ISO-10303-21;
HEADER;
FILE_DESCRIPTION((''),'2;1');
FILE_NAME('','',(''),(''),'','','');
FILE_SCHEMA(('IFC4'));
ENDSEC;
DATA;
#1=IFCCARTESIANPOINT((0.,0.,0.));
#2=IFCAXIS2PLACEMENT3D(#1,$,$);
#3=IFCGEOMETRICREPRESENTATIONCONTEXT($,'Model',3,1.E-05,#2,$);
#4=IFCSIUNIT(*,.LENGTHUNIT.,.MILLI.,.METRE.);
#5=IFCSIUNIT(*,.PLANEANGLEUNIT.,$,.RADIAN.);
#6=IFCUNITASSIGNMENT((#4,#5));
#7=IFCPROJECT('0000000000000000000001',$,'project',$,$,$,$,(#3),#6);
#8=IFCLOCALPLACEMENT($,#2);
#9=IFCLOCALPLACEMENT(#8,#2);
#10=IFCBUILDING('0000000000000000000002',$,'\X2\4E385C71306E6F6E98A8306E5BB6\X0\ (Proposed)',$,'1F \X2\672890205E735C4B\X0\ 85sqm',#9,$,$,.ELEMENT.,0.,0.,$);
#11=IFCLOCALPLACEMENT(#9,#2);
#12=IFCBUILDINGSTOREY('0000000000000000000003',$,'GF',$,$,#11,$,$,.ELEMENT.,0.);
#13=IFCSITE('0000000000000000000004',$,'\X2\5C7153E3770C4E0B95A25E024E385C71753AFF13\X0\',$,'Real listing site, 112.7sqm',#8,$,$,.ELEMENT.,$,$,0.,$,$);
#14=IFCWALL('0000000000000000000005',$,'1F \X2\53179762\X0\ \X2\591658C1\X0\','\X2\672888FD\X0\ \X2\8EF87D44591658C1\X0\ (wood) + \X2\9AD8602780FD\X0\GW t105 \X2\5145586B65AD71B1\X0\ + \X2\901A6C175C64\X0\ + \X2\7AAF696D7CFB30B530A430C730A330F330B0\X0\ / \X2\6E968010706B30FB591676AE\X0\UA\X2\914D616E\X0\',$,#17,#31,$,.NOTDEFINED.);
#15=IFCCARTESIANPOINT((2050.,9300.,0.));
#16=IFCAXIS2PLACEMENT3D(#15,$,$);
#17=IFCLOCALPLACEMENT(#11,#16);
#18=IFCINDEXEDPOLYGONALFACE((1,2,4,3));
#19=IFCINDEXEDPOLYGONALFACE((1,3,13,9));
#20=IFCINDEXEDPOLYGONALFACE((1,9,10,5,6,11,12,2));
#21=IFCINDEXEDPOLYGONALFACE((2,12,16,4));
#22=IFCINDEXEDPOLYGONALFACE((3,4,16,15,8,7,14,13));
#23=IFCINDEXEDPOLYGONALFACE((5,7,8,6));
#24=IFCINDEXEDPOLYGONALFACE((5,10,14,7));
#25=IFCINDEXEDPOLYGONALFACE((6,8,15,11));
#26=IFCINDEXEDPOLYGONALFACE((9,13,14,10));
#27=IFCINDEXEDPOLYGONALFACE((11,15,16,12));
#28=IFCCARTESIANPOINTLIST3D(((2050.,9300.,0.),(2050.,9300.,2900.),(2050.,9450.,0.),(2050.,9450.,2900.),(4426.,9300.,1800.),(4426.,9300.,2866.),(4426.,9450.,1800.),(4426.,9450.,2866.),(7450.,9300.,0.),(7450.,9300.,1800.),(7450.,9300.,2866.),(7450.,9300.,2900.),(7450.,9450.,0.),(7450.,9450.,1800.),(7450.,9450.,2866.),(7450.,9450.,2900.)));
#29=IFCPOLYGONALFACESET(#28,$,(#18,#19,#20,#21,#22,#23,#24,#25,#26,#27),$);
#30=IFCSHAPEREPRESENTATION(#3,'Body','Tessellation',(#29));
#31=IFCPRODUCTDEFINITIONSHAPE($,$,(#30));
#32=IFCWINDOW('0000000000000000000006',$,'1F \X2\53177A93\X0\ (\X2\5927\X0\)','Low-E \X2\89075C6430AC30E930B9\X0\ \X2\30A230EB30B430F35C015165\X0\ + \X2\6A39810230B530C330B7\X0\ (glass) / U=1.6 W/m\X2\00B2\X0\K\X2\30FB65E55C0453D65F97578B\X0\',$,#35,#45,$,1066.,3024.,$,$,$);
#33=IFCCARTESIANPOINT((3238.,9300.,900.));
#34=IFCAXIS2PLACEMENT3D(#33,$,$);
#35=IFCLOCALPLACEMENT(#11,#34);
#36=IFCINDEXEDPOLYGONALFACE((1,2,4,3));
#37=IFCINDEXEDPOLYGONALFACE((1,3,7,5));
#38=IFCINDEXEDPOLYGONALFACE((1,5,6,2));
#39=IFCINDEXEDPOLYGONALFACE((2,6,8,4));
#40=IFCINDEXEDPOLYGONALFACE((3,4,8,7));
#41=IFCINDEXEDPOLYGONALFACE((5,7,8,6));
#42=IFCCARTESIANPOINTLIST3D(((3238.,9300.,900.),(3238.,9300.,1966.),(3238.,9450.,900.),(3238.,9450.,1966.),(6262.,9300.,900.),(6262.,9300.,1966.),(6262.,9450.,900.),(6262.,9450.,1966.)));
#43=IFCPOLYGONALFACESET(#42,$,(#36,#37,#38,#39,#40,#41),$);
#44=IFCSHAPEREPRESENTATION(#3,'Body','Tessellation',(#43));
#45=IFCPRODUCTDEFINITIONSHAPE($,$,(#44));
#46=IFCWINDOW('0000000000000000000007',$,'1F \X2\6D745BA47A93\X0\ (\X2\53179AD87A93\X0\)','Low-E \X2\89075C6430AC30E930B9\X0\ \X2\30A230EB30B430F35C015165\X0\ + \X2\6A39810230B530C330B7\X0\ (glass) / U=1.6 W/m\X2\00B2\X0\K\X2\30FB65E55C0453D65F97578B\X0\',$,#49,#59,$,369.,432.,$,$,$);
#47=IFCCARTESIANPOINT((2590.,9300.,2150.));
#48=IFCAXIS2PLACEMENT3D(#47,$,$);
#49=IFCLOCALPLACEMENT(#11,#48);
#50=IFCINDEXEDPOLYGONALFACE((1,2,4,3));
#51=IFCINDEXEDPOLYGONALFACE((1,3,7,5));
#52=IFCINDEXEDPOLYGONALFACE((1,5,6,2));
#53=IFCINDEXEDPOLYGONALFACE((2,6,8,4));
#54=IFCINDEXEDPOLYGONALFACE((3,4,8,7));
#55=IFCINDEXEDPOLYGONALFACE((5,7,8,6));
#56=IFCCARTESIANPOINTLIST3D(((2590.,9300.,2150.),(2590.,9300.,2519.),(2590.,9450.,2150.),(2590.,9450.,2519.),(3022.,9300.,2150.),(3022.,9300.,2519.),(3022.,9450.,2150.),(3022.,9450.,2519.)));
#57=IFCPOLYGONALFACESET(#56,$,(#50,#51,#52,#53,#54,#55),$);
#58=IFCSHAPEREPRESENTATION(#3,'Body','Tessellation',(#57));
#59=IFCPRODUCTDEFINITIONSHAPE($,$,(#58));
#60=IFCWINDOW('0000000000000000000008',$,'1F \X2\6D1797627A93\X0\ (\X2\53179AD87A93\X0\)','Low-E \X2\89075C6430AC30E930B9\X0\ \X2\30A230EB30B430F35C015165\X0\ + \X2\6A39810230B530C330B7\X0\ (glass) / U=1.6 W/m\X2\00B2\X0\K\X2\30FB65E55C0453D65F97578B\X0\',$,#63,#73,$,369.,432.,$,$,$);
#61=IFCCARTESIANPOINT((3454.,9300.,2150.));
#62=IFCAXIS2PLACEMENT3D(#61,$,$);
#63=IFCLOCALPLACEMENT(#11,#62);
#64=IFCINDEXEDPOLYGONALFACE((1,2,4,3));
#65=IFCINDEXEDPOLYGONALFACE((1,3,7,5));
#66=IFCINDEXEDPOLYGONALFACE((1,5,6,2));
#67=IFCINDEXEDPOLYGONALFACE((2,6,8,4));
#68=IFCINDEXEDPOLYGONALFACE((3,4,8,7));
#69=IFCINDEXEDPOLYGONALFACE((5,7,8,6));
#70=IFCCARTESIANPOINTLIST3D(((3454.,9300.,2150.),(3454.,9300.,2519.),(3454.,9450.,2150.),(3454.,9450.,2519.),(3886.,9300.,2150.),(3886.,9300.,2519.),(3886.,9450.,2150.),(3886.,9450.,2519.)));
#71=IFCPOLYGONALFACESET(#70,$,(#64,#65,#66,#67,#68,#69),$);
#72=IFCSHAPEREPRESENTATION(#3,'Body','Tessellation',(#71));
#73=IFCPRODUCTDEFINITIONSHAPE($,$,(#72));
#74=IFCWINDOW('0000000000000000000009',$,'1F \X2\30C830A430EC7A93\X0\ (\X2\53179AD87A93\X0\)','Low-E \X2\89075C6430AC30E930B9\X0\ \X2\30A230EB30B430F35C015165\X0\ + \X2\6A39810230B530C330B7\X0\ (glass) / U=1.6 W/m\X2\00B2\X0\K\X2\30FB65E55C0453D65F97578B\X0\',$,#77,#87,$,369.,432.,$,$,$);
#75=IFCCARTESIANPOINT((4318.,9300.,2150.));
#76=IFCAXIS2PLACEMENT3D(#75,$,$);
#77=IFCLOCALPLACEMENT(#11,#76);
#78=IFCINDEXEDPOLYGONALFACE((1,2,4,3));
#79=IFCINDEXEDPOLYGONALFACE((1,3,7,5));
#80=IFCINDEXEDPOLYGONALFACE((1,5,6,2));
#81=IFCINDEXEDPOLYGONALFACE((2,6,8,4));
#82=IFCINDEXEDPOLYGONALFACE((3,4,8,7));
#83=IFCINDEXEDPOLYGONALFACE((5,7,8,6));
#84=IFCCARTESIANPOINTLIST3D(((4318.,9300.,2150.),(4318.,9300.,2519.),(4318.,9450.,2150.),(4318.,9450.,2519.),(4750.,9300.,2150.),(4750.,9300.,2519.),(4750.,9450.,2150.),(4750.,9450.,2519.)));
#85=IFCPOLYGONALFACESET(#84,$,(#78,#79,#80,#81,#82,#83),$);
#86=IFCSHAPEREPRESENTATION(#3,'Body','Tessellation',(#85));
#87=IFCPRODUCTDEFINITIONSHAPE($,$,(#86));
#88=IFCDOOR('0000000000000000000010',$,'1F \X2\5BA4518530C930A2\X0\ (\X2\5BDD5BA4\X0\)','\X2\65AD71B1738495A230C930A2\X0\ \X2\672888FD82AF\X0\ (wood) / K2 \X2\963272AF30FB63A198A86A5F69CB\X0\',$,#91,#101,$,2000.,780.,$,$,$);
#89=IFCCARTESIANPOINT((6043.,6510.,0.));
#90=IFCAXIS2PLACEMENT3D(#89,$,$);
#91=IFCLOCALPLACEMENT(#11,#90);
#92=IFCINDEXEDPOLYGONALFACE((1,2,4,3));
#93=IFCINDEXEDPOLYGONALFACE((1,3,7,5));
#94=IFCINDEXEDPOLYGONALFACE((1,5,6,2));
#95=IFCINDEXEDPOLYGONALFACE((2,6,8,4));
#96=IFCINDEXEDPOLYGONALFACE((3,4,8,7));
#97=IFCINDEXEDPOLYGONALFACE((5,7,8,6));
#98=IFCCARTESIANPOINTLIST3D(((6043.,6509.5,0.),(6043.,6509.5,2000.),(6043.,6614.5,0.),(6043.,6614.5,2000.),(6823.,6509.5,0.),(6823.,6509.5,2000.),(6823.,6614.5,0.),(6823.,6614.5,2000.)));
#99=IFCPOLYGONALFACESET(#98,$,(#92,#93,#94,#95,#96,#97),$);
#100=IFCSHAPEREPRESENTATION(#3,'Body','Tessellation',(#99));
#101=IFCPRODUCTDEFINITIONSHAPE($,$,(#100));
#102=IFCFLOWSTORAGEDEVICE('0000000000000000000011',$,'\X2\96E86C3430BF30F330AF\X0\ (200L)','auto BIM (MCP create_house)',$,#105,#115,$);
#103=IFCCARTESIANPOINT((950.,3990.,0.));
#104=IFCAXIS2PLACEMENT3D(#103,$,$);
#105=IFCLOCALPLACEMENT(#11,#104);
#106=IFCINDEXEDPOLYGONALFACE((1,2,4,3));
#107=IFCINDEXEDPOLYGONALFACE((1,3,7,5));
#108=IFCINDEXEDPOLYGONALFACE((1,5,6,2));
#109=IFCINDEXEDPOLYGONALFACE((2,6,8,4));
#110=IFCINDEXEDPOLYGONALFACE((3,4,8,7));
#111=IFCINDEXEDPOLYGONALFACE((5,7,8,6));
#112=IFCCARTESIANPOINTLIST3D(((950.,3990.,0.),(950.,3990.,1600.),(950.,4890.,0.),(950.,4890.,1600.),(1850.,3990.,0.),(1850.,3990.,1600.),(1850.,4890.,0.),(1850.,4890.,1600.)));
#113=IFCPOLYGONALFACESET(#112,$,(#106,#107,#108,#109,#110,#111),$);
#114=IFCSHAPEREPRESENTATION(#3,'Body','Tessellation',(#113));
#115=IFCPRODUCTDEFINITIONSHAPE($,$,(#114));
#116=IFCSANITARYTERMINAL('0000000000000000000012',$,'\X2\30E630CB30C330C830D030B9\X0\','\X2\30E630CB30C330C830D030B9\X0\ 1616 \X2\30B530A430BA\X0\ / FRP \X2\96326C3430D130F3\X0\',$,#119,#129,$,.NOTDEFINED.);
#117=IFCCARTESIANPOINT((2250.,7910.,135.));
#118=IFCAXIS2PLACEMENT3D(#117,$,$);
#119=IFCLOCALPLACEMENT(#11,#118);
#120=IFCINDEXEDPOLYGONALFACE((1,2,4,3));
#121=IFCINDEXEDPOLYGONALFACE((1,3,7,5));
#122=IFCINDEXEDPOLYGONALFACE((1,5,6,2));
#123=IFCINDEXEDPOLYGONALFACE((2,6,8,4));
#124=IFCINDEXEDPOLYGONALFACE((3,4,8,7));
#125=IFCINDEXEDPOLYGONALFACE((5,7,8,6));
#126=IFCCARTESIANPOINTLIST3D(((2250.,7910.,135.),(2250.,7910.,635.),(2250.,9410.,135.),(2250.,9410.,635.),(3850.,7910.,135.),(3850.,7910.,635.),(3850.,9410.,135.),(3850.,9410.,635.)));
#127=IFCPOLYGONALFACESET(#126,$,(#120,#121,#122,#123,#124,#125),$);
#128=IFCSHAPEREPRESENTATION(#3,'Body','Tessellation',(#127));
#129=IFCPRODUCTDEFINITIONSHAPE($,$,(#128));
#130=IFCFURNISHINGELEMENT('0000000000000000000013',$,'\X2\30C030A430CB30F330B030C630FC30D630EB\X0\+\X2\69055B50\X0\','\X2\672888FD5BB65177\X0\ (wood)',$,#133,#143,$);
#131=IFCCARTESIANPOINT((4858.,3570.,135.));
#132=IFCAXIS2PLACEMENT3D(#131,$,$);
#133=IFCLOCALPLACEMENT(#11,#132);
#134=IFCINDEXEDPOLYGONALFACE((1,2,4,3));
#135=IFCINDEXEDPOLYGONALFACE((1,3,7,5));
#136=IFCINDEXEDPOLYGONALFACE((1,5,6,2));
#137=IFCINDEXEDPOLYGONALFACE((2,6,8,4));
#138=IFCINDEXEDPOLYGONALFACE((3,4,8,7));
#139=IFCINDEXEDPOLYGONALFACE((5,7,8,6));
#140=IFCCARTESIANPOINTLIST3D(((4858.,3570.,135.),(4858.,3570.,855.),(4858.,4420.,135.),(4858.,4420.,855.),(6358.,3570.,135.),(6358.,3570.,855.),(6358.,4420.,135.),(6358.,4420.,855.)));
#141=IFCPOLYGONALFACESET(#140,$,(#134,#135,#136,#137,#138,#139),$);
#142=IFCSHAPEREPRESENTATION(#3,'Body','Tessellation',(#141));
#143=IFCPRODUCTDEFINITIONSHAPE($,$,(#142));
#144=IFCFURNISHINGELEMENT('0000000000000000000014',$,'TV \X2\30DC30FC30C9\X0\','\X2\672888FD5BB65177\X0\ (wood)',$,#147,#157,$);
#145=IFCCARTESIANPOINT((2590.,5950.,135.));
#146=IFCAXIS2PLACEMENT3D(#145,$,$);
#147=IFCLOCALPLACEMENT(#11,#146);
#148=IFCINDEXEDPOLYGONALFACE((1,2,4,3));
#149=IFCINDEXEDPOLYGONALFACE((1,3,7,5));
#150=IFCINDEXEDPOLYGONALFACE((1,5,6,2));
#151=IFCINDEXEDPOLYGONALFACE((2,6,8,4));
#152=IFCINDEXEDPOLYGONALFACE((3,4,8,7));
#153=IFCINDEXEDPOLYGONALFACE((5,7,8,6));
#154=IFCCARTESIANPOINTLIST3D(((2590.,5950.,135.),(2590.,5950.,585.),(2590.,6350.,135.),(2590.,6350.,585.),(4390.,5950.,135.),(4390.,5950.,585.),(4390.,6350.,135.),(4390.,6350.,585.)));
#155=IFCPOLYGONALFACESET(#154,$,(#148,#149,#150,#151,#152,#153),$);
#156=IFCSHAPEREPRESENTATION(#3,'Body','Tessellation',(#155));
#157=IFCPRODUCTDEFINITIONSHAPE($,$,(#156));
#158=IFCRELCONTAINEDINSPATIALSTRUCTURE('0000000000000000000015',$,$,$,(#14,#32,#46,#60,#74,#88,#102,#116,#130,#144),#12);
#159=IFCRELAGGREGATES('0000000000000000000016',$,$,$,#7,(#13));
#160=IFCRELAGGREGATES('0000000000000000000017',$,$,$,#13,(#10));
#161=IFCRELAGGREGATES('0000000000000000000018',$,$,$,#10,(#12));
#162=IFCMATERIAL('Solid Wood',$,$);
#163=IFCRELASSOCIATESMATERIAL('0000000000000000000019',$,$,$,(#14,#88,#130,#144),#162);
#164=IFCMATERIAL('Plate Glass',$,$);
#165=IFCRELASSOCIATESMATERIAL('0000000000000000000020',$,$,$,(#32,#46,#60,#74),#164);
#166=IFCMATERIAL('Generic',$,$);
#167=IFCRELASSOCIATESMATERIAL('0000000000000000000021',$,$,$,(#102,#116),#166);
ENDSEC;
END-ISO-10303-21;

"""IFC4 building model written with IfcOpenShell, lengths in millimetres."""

from ifc_helpers import new_model, si_unit, frame, frame_2d, origin, place, context, project, spatial, rectangle, extrude, material, element, fill, save


model = new_model("IFC4")

# Units and contexts
model_context = context("Model", 3, precision=1e-05, world=origin())
ifc_project = project(units=[si_unit("LENGTHUNIT", "METRE", prefix="MILLI"), si_unit("PLANEANGLEUNIT", "RADIAN")], contexts=[model_context])

# Site, building, storey
site_placement = place(None, origin())
site = spatial("IfcSite", under=ifc_project, at=site_placement, Name="山口県下関市丸山町３", ObjectType="Real listing site, 112.7sqm", CompositionType="ELEMENT", RefElevation=0.0)
building_placement = place(site_placement, origin())
building = spatial("IfcBuilding", under=site, at=building_placement, Name="丸山の潮風の家 (Proposed)", ObjectType="1F 木造平屋 85sqm", CompositionType="ELEMENT", ElevationOfRefHeight=0.0, ElevationOfTerrain=0.0)
storey_placement = place(building_placement, origin())
storey = spatial("IfcBuildingStorey", under=building, at=storey_placement, Name="GF", CompositionType="ELEMENT", Elevation=0.0)

# Wall, openings, windows
ifc_material_1 = material(Name="Solid Wood")
wall_1_placement = place(storey_placement, frame((2050.0, 9300.0, 0.0)))
wall_1 = element("IfcWall", 1, at=wall_1_placement, inside=storey, material=ifc_material_1, Name="1F 北面 外壁", Description="木製 軸組外壁 (wood) + 高性能GW t105 充填断熱 + 通気層 + 窯業系サイディング / 準耐火・外皮UA配慮", PredefinedType="NOTDEFINED", context=model_context, shape_type="SweptSolid", body=[
    extrude(rectangle(XDim=5400.0, YDim=150.0, at=frame_2d((2700.0, 75.0))), frame((2050.0, 9300.0, 0.0)), (0.0, 0.0, 1.0), 2900.0),
])
opening_1_placement = place(storey_placement, frame((3238.0, 9300.0, 900.0)))
opening_1 = element("IfcOpeningElement", 2, at=opening_1_placement, cuts=wall_1, PredefinedType="NOTDEFINED", context=model_context, shape_type="SweptSolid", body=[
    extrude(rectangle(XDim=3024.0, YDim=150.0, at=frame_2d((1512.0, 75.0))), frame((3238.0, 9300.0, 900.0)), (0.0, 0.0, 1.0), 1066.0),
])
opening_2_placement = place(storey_placement, frame((2590.0, 9300.0, 2150.0)))
opening_2 = element("IfcOpeningElement", 3, at=opening_2_placement, cuts=wall_1, PredefinedType="NOTDEFINED", context=model_context, shape_type="SweptSolid", body=[
    extrude(rectangle(XDim=432.0, YDim=150.0, at=frame_2d((216.0, 75.0))), frame((2590.0, 9300.0, 2150.0)), (0.0, 0.0, 1.0), 369.0),
])
opening_3_placement = place(storey_placement, frame((3454.0, 9300.0, 2150.0)))
opening_3 = element("IfcOpeningElement", 4, at=opening_3_placement, cuts=wall_1, PredefinedType="NOTDEFINED", context=model_context, shape_type="SweptSolid", body=[
    extrude(rectangle(XDim=432.0, YDim=150.0, at=frame_2d((216.0, 75.0))), frame((3454.0, 9300.0, 2150.0)), (0.0, 0.0, 1.0), 369.0),
])
opening_4_placement = place(storey_placement, frame((4318.0, 9300.0, 2150.0)))
opening_4 = element("IfcOpeningElement", 5, at=opening_4_placement, cuts=wall_1, PredefinedType="NOTDEFINED", context=model_context, shape_type="SweptSolid", body=[
    extrude(rectangle(XDim=432.0, YDim=150.0, at=frame_2d((216.0, 75.0))), frame((4318.0, 9300.0, 2150.0)), (0.0, 0.0, 1.0), 369.0),
])
ifc_material_2 = material(Name="Plate Glass")
window_1_placement = place(storey_placement, frame((3238.0, 9300.0, 900.0)))
window_1 = element("IfcWindow", 6, at=window_1_placement, inside=storey, material=ifc_material_2, Name="1F 北窓 (大)", Description="Low-E 複層ガラス アルゴン封入 + 樹脂サッシ (glass) / U=1.6 W/m²K・日射取得型", OverallHeight=1066.0, OverallWidth=3024.0, context=model_context, shape_type="SweptSolid", body=[
    extrude(rectangle(XDim=3024.0, YDim=150.0, at=frame_2d((1512.0, 75.0))), frame((3238.0, 9300.0, 900.0)), (0.0, 0.0, 1.0), 1066.0),
])
fill(opening_1, window_1)
window_2_placement = place(storey_placement, frame((2590.0, 9300.0, 2150.0)))
window_2 = element("IfcWindow", 7, at=window_2_placement, inside=storey, material=ifc_material_2, Name="1F 浴室窓 (北高窓)", Description="Low-E 複層ガラス アルゴン封入 + 樹脂サッシ (glass) / U=1.6 W/m²K・日射取得型", OverallHeight=369.0, OverallWidth=432.0, context=model_context, shape_type="SweptSolid", body=[
    extrude(rectangle(XDim=432.0, YDim=150.0, at=frame_2d((216.0, 75.0))), frame((2590.0, 9300.0, 2150.0)), (0.0, 0.0, 1.0), 369.0),
])
fill(opening_2, window_2)
window_3_placement = place(storey_placement, frame((3454.0, 9300.0, 2150.0)))
window_3 = element("IfcWindow", 8, at=window_3_placement, inside=storey, material=ifc_material_2, Name="1F 洗面窓 (北高窓)", Description="Low-E 複層ガラス アルゴン封入 + 樹脂サッシ (glass) / U=1.6 W/m²K・日射取得型", OverallHeight=369.0, OverallWidth=432.0, context=model_context, shape_type="SweptSolid", body=[
    extrude(rectangle(XDim=432.0, YDim=150.0, at=frame_2d((216.0, 75.0))), frame((3454.0, 9300.0, 2150.0)), (0.0, 0.0, 1.0), 369.0),
])
fill(opening_3, window_3)
window_4_placement = place(storey_placement, frame((4318.0, 9300.0, 2150.0)))
window_4 = element("IfcWindow", 9, at=window_4_placement, inside=storey, material=ifc_material_2, Name="1F トイレ窓 (北高窓)", Description="Low-E 複層ガラス アルゴン封入 + 樹脂サッシ (glass) / U=1.6 W/m²K・日射取得型", OverallHeight=369.0, OverallWidth=432.0, context=model_context, shape_type="SweptSolid", body=[
    extrude(rectangle(XDim=432.0, YDim=150.0, at=frame_2d((216.0, 75.0))), frame((4318.0, 9300.0, 2150.0)), (0.0, 0.0, 1.0), 369.0),
])
fill(opening_4, window_4)

# Door
door_1_placement = place(storey_placement, frame((6043.0, 6510.0, 0.0)))
element("IfcDoor", 10, at=door_1_placement, inside=storey, material=ifc_material_1, Name="1F 室内ドア (寝室)", Description="断熱玄関ドア 木製芯 (wood) / K2 防犯・採風機構", OverallHeight=2000.0, OverallWidth=780.0, context=model_context, shape_type="SweptSolid", body=[
    extrude(rectangle(XDim=780.0, YDim=105.0, at=frame_2d((390.0, 52.0))), frame((6043.0, 6510.0, 0.0)), (0.0, 0.0, 1.0), 2000.0),
])

# Flow storage device
ifc_material_3 = material(Name="Generic")
flow_storage_device_placement = place(storey_placement, frame((950.0, 3990.0, 0.0)))
element("IfcFlowStorageDevice", 11, at=flow_storage_device_placement, inside=storey, material=ifc_material_3, Name="雨水タンク (200L)", Description="auto BIM (MCP create_house)", context=model_context, shape_type="SweptSolid", body=[
    extrude(rectangle(XDim=900.0, YDim=900.0, at=frame_2d((450.0, 450.0))), frame((950.0, 3990.0, 0.0)), (0.0, 0.0, 1.0), 1600.0),
])

# Sanitary terminal
sanitary_terminal_placement = place(storey_placement, frame((2250.0, 7910.0, 135.0)))
element("IfcSanitaryTerminal", 12, at=sanitary_terminal_placement, inside=storey, material=ifc_material_3, Name="ユニットバス", Description="ユニットバス 1616 サイズ / FRP 防水パン", PredefinedType="NOTDEFINED", context=model_context, shape_type="SweptSolid", body=[
    extrude(rectangle(XDim=1600.0, YDim=1500.0, at=frame_2d((800.0, 750.0))), frame((2250.0, 7910.0, 135.0)), (0.0, 0.0, 1.0), 500.0),
])

# Furnishing elements
furnishing_1_placement = place(storey_placement, frame((4858.0, 3570.0, 135.0)))
element("IfcFurnishingElement", 13, at=furnishing_1_placement, inside=storey, material=ifc_material_1, Name="ダイニングテーブル+椅子", Description="木製家具 (wood)", context=model_context, shape_type="SweptSolid", body=[
    extrude(rectangle(XDim=1500.0, YDim=850.0, at=frame_2d((750.0, 425.0))), frame((4858.0, 3570.0, 135.0)), (0.0, 0.0, 1.0), 720.0),
])
furnishing_2_placement = place(storey_placement, frame((2590.0, 5950.0, 135.0)))
element("IfcFurnishingElement", 14, at=furnishing_2_placement, inside=storey, material=ifc_material_1, Name="TV ボード", Description="木製家具 (wood)", context=model_context, shape_type="SweptSolid", body=[
    extrude(rectangle(XDim=1800.0, YDim=400.0, at=frame_2d((900.0, 200.0))), frame((2590.0, 5950.0, 135.0)), (0.0, 0.0, 1.0), 450.0),
])

save(model, "model.ifc")
